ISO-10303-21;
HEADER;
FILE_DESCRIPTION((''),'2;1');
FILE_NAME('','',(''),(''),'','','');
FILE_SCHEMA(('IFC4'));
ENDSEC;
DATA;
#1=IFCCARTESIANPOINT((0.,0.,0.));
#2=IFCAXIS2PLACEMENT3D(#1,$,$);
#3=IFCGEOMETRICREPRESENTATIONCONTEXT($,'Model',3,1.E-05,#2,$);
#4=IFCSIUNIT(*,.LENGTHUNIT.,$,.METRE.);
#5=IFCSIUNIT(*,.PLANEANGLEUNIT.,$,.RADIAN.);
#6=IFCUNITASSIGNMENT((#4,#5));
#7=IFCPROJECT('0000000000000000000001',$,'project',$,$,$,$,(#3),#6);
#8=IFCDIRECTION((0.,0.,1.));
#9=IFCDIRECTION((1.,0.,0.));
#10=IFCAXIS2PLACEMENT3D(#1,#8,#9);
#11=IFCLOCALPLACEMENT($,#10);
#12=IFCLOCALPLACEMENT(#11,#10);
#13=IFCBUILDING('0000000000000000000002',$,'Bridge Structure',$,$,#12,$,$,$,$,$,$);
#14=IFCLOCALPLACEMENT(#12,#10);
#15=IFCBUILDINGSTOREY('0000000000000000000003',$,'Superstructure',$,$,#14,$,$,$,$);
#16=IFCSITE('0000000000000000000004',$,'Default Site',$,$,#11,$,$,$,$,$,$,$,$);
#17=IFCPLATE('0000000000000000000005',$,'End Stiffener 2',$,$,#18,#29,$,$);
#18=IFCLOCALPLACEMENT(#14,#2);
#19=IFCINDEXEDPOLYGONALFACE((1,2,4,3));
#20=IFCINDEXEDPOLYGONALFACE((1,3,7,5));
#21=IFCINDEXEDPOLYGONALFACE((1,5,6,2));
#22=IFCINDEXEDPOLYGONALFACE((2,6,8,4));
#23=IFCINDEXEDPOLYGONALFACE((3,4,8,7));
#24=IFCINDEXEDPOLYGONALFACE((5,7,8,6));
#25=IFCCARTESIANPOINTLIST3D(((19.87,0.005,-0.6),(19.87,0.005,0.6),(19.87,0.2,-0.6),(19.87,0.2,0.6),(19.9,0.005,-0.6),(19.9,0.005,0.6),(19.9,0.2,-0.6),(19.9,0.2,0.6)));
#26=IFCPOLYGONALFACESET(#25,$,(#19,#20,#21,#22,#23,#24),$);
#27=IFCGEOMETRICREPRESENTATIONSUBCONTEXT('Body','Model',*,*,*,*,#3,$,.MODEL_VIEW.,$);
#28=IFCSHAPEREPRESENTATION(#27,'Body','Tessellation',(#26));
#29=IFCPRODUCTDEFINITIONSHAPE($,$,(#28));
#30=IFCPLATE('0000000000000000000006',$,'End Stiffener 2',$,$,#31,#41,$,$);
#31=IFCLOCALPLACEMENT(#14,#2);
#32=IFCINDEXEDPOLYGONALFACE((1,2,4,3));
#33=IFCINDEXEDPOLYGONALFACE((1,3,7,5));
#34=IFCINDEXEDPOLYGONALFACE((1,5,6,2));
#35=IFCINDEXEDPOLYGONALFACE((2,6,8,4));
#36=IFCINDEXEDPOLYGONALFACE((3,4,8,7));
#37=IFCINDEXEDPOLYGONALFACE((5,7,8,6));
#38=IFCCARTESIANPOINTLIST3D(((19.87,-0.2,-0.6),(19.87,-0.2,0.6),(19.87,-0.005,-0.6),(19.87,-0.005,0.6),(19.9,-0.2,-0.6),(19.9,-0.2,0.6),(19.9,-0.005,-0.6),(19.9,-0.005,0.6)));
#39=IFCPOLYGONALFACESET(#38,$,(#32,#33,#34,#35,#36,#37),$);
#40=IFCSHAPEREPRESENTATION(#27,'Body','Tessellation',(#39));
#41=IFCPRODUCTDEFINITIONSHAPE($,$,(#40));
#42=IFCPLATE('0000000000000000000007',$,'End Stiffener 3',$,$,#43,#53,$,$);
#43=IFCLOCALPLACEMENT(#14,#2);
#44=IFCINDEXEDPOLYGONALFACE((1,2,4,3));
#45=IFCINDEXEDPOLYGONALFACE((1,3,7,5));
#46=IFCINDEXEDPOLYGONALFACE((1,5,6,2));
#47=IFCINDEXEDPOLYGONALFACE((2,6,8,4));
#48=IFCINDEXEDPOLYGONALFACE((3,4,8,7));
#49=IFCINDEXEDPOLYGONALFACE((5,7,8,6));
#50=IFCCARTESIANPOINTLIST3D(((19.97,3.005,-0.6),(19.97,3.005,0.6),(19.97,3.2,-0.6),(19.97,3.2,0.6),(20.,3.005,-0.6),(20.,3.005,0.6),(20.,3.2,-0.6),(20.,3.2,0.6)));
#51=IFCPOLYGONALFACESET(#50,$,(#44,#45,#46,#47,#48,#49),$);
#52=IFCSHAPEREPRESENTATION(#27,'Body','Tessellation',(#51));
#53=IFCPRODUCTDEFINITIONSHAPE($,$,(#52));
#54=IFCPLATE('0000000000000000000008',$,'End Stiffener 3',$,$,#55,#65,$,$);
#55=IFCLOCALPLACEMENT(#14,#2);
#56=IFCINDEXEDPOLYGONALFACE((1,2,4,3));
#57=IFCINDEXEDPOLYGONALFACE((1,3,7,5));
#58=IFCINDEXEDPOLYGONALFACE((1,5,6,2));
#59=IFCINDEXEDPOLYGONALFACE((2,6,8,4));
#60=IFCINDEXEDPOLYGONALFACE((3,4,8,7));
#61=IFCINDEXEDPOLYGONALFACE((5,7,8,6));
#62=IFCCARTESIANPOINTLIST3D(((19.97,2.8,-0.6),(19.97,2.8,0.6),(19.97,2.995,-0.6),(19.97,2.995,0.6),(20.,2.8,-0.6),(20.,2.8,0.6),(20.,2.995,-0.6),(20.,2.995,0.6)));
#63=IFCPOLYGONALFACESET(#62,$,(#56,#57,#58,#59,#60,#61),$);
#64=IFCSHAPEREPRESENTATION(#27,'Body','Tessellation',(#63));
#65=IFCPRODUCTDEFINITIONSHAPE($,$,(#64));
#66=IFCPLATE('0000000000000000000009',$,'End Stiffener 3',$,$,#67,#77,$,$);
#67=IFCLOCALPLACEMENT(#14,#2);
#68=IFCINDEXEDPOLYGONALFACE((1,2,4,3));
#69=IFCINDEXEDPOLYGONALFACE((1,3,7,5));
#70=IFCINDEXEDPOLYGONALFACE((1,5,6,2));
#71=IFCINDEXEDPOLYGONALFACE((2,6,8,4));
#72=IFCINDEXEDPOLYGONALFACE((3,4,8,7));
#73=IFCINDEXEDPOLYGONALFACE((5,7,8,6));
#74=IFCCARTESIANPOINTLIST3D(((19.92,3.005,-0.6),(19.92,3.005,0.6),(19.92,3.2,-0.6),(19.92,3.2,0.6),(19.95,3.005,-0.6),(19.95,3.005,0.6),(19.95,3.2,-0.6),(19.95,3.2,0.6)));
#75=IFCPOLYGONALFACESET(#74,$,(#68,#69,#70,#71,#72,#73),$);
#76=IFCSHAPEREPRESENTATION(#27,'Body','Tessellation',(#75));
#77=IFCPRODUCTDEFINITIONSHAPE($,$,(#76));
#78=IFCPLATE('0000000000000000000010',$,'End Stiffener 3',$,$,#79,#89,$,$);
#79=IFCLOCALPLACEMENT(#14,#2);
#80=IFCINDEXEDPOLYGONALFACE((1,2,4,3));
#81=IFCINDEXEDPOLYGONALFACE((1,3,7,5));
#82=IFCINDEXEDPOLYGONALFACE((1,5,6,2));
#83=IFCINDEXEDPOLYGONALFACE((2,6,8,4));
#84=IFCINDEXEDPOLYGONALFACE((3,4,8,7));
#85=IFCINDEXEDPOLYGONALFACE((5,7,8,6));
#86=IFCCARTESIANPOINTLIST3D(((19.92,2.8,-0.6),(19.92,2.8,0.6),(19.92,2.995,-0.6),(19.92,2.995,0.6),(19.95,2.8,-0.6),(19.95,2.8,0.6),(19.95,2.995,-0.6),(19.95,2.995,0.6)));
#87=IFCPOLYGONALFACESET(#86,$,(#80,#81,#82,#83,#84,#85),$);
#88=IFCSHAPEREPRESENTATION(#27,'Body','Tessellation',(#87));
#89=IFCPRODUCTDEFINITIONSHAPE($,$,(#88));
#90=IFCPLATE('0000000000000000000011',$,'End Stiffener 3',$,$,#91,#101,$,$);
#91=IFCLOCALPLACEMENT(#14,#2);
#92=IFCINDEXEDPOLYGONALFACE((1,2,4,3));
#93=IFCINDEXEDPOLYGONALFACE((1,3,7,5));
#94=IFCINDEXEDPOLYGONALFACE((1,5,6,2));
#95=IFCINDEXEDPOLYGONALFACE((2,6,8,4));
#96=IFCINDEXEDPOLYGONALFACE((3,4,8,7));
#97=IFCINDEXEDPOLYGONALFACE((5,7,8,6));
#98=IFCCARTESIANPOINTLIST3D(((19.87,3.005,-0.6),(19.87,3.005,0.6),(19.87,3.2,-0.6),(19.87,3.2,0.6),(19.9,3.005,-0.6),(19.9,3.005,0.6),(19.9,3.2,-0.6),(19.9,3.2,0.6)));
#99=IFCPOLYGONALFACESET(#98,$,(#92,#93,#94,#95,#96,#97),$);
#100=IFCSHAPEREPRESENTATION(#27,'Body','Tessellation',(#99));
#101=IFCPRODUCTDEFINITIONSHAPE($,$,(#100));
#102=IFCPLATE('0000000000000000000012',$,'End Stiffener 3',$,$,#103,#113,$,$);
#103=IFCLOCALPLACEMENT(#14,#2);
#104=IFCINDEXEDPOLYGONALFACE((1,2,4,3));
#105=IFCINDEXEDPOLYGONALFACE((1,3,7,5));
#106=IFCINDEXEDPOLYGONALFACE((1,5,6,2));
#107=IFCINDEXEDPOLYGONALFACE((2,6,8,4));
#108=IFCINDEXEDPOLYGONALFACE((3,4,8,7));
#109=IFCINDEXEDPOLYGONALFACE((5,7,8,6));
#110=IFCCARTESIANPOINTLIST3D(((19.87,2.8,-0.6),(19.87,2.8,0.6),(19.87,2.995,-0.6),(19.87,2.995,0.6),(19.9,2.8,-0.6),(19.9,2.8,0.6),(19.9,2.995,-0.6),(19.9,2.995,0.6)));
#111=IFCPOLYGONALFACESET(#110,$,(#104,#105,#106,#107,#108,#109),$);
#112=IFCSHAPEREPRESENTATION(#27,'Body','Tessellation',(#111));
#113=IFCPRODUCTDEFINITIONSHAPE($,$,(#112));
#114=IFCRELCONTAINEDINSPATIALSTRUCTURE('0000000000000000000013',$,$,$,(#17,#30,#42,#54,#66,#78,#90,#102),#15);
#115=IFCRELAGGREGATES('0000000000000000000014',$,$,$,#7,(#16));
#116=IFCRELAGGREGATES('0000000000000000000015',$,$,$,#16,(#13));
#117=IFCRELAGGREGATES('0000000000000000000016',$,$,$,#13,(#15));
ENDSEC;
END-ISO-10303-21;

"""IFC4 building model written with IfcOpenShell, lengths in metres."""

from ifc_helpers import new_model, si_unit, frame, origin, origin_with_axes, origin_2d_with_axis, place, context, subcontext, project, spatial, rectangle, extrude, element, save


model = new_model("IFC4")

# Units and contexts
model_context = context("Model", 3, precision=1e-05, world=origin())
body_context = subcontext(model_context, "Body", "Model", "MODEL_VIEW")
ifc_project = project(units=[si_unit("LENGTHUNIT", "METRE"), si_unit("PLANEANGLEUNIT", "RADIAN")], contexts=[model_context])

# Site, building, storey
site_placement = place(None, origin_with_axes())
site = spatial("IfcSite", under=ifc_project, at=site_placement, Name="Default Site")
building_placement = place(site_placement, origin_with_axes())
building = spatial("IfcBuilding", under=site, at=building_placement, Name="Bridge Structure")
storey_placement = place(building_placement, origin_with_axes())
storey = spatial("IfcBuildingStorey", under=building, at=storey_placement, Name="Superstructure")

# Plates
for number, where, z_axis, x_axis, name in (
    (1, (19.885, 0.1025, -0.6), (0.0, 0.0, 1.0), (1.0, 0.0, 0.0), "End Stiffener 2"),
    (2, (19.885, -0.1025, -0.6), (0.0, 0.0, 1.0), (1.0, 0.0, 0.0), "End Stiffener 2"),
    (3, (19.985, 3.1025, -0.6), (0.0, 0.0, 1.0), (1.0, 0.0, 0.0), "End Stiffener 3"),
    (4, (19.985, 2.8975, -0.6), (0.0, 0.0, 1.0), (1.0, 0.0, 0.0), "End Stiffener 3"),
    (5, (19.935, 3.1025, -0.6), (0.0, 0.0, 1.0), (1.0, 0.0, 0.0), "End Stiffener 3"),
    (6, (19.935, 2.8975, -0.6), (0.0, 0.0, 1.0), (1.0, 0.0, 0.0), "End Stiffener 3"),
    (7, (19.885, 3.1025, -0.6), (0.0, 0.0, 1.0), (1.0, 0.0, 0.0), "End Stiffener 3"),
    (8, (19.885, 2.8975, -0.6), (0.0, 0.0, 1.0), (1.0, 0.0, 0.0), "End Stiffener 3"),
):
    element("IfcPlate", number, at=place(storey_placement, frame(where, z_axis=z_axis, x_axis=x_axis)), inside=storey, Name=name, context=body_context, shape_type="SweptSolid", body=[
        extrude(rectangle(XDim=0.03, YDim=0.195, at=origin_2d_with_axis()), origin_with_axes(), (0.0, 0.0, 1.0), 1.2),
    ])

save(model, "model.ifc")
